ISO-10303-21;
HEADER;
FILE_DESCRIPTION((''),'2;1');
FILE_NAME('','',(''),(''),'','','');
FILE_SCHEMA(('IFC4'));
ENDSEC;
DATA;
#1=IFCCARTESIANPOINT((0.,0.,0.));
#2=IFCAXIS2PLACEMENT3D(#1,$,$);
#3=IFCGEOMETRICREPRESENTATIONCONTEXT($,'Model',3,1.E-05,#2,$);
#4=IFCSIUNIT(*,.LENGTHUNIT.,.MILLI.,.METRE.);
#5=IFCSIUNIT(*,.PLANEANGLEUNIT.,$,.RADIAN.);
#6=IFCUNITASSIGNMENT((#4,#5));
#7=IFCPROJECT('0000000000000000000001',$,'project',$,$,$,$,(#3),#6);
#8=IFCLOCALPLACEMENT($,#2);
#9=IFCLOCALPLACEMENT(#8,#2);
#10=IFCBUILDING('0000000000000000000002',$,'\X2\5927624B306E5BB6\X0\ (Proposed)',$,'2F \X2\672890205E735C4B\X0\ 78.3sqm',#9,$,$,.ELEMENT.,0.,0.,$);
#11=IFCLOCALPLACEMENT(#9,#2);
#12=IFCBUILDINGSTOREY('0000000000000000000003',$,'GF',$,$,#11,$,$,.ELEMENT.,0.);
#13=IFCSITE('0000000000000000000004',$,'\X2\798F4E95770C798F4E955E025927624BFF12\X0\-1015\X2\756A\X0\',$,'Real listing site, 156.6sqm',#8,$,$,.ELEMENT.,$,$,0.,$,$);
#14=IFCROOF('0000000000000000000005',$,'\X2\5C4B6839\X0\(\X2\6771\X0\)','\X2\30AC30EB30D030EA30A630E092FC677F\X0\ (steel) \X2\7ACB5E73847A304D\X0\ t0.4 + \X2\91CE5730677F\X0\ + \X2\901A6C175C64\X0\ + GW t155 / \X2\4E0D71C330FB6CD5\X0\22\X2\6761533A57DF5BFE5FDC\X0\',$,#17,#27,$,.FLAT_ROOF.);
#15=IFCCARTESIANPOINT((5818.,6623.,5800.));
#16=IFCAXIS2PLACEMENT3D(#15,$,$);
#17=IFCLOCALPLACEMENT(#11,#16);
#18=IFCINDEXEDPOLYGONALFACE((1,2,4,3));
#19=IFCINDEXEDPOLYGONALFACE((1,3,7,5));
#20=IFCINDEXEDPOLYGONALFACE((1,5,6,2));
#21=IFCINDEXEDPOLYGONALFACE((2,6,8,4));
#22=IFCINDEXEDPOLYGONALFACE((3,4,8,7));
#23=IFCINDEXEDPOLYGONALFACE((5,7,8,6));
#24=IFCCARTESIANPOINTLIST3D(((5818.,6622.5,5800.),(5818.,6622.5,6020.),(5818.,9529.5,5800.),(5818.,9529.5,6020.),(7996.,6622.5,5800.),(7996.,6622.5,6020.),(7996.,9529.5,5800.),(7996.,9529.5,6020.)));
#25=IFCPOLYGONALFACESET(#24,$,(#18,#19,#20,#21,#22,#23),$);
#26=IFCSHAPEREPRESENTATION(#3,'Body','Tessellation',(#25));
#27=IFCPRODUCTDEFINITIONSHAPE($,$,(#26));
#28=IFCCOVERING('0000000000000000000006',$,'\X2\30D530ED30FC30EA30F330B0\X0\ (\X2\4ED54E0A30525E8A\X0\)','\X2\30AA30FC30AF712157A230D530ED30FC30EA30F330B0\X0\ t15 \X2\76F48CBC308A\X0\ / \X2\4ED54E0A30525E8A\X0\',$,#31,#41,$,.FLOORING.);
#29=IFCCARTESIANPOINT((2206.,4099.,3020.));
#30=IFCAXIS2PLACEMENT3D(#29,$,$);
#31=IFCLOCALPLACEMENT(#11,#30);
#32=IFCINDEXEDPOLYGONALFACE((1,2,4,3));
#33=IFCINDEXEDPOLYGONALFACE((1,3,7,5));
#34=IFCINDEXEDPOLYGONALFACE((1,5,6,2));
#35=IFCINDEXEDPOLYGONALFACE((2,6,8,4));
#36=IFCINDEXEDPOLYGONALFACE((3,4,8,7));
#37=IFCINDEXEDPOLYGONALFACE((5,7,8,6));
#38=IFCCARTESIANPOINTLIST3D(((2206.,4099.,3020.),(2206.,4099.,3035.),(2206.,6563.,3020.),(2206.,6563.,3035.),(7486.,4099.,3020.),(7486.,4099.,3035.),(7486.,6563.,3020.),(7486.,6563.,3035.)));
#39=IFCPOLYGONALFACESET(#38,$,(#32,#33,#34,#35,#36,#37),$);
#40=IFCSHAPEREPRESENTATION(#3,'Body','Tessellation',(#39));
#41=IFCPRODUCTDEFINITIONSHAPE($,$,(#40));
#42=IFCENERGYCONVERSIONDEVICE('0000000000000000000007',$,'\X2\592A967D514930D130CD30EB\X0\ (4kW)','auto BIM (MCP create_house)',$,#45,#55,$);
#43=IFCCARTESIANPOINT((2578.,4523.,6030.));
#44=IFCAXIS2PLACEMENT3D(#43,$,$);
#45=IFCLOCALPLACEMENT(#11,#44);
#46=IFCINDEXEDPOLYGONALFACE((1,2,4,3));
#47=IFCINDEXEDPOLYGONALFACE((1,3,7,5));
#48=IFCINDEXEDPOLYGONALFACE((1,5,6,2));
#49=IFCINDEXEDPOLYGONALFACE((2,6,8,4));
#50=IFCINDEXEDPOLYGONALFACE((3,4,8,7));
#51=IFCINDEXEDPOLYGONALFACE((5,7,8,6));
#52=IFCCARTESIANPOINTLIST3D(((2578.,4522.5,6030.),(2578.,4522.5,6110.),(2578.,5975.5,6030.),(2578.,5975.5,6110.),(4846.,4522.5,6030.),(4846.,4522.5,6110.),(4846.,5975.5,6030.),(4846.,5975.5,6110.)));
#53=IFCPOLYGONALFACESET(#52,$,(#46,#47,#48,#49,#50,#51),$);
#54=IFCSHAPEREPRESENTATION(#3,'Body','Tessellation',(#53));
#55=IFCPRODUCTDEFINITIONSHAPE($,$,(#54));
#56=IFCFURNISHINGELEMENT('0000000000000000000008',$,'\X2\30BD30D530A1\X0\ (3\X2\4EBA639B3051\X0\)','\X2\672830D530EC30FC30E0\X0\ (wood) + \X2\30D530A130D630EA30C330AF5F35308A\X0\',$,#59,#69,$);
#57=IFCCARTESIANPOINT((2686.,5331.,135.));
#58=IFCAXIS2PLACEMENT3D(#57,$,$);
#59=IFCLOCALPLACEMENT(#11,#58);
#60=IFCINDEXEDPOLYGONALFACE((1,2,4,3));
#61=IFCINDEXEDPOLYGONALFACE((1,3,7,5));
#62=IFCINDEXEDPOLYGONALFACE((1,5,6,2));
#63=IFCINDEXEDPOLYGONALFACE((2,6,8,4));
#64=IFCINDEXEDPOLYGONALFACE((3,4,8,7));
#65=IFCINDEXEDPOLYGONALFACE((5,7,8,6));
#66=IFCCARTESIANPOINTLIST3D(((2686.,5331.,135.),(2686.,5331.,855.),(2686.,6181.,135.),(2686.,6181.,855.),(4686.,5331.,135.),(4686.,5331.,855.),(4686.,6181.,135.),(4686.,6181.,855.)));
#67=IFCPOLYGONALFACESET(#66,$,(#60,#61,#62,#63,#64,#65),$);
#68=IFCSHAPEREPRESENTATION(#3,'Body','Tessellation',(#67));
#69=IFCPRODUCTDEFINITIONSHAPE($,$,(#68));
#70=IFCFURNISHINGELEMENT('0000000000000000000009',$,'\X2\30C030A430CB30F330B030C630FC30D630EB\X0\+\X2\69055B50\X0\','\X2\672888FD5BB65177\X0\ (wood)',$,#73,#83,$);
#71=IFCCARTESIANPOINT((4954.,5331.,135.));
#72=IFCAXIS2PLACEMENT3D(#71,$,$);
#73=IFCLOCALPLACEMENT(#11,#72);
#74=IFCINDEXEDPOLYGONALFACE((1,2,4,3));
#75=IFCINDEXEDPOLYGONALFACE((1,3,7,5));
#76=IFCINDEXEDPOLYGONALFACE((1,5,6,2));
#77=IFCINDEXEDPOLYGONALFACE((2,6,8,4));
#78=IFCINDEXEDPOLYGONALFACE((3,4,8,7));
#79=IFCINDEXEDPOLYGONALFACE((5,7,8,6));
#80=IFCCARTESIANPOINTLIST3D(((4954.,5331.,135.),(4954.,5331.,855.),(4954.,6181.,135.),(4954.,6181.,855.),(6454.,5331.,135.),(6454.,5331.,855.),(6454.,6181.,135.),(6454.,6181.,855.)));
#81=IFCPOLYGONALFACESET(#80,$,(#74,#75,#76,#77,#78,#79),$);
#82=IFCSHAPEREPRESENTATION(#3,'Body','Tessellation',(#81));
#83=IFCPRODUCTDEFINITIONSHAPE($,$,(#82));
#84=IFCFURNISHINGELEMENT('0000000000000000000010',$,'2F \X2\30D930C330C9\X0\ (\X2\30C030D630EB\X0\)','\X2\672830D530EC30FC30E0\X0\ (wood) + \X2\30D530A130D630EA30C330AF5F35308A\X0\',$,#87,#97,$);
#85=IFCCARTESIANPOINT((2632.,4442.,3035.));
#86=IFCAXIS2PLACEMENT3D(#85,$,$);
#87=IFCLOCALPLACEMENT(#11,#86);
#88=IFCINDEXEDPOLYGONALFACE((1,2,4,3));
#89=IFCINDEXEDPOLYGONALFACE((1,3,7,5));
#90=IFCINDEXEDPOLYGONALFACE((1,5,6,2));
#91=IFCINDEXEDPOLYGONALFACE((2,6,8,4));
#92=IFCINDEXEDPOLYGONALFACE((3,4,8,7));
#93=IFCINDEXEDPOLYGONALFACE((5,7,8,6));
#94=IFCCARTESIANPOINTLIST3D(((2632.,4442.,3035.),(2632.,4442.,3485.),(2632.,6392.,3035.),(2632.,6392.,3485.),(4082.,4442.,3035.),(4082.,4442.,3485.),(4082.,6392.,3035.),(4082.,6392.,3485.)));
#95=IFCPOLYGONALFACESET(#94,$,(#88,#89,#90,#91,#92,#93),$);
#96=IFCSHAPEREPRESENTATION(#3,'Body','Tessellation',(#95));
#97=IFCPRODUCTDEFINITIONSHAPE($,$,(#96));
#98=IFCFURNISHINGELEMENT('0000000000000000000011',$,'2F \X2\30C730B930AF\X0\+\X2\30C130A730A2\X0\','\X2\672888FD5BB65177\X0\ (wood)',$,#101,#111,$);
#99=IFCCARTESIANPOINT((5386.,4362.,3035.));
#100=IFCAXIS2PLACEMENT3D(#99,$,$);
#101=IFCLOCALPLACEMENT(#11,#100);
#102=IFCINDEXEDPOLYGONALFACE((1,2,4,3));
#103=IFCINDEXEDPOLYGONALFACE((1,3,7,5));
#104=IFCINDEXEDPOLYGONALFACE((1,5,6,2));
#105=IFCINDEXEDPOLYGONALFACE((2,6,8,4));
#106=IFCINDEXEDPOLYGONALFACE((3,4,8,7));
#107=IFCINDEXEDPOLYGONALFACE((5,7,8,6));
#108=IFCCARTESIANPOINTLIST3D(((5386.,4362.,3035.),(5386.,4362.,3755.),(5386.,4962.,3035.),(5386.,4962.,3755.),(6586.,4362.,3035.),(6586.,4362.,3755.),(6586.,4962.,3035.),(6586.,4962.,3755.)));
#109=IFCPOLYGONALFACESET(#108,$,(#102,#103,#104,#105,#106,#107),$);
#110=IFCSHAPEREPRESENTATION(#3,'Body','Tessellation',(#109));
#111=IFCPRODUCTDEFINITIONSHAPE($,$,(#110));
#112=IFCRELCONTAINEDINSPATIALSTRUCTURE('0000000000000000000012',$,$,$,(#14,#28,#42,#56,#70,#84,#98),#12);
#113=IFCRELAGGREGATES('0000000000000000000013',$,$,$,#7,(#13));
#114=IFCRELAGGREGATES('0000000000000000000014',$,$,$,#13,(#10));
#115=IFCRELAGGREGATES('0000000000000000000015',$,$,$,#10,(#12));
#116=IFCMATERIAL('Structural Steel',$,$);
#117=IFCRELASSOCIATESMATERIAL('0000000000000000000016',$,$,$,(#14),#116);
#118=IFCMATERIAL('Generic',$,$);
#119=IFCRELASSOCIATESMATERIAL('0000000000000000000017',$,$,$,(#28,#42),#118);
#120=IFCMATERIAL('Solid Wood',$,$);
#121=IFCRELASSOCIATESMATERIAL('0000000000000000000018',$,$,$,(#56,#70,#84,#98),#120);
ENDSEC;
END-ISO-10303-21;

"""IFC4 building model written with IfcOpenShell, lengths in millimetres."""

from ifc_helpers import new_model, si_unit, frame, frame_2d, origin, place, context, project, spatial, rectangle, extrude, material, element, save


model = new_model("IFC4")

# Units and contexts
model_context = context("Model", 3, precision=1e-05, world=origin())
ifc_project = project(units=[si_unit("LENGTHUNIT", "METRE", prefix="MILLI"), si_unit("PLANEANGLEUNIT", "RADIAN")], contexts=[model_context])

# Site, building, storey
site_placement = place(None, origin())
site = spatial("IfcSite", under=ifc_project, at=site_placement, Name="福井県福井市大手２-1015番", ObjectType="Real listing site, 156.6sqm", CompositionType="ELEMENT", RefElevation=0.0)
building_placement = place(site_placement, origin())
building = spatial("IfcBuilding", under=site, at=building_placement, Name="大手の家 (Proposed)", ObjectType="2F 木造平屋 78.3sqm", CompositionType="ELEMENT", ElevationOfRefHeight=0.0, ElevationOfTerrain=0.0)
storey_placement = place(building_placement, origin())
storey = spatial("IfcBuildingStorey", under=building, at=storey_placement, Name="GF", CompositionType="ELEMENT", Elevation=0.0)

# Shared definitions
ifc_material_1 = material(Name="Solid Wood")

# Roof
ifc_material_2 = material(Name="Structural Steel")
roof_1_placement = place(storey_placement, frame((5818.0, 6623.0, 5800.0)))
element("IfcRoof", 1, at=roof_1_placement, inside=storey, material=ifc_material_2, Name="屋根(東)", Description="ガルバリウム鋼板 (steel) 立平葺き t0.4 + 野地板 + 通気層 + GW t155 / 不燃・法22条区域対応", PredefinedType="FLAT_ROOF", context=model_context, shape_type="SweptSolid", body=[
    extrude(rectangle(XDim=2178.0, YDim=2907.0, at=frame_2d((1089.0, 1453.0))), frame((5818.0, 6623.0, 5800.0)), (0.0, 0.0, 1.0), 220.0),
])

# Covering
ifc_material_3 = material(Name="Generic")
covering_placement = place(storey_placement, frame((2206.0, 4099.0, 3020.0)))
element("IfcCovering", 2, at=covering_placement, inside=storey, material=ifc_material_3, Name="フローリング (仕上げ床)", Description="オーク無垢フローリング t15 直貼り / 仕上げ床", PredefinedType="FLOORING", context=model_context, shape_type="SweptSolid", body=[
    extrude(rectangle(XDim=5280.0, YDim=2464.0, at=frame_2d((2640.0, 1232.0))), frame((2206.0, 4099.0, 3020.0)), (0.0, 0.0, 1.0), 15.0),
])

# Energy conversion device
energy_conversion_device_placement = place(storey_placement, frame((2578.0, 4523.0, 6030.0)))
element("IfcEnergyConversionDevice", 3, at=energy_conversion_device_placement, inside=storey, material=ifc_material_3, Name="太陽光パネル (4kW)", Description="auto BIM (MCP create_house)", context=model_context, shape_type="SweptSolid", body=[
    extrude(rectangle(XDim=2268.0, YDim=1453.0, at=frame_2d((1134.0, 726.0))), frame((2578.0, 4523.0, 6030.0)), (0.0, 0.0, 1.0), 80.0),
])

# Furnishing elements
furnishing_1_placement = place(storey_placement, frame((2686.0, 5331.0, 135.0)))
element("IfcFurnishingElement", 4, at=furnishing_1_placement, inside=storey, material=ifc_material_1, Name="ソファ (3人掛け)", Description="木フレーム (wood) + ファブリック張り", context=model_context, shape_type="SweptSolid", body=[
    extrude(rectangle(XDim=2000.0, YDim=850.0, at=frame_2d((1000.0, 425.0))), frame((2686.0, 5331.0, 135.0)), (0.0, 0.0, 1.0), 720.0),
])
furnishing_2_placement = place(storey_placement, frame((4954.0, 5331.0, 135.0)))
element("IfcFurnishingElement", 5, at=furnishing_2_placement, inside=storey, material=ifc_material_1, Name="ダイニングテーブル+椅子", Description="木製家具 (wood)", context=model_context, shape_type="SweptSolid", body=[
    extrude(rectangle(XDim=1500.0, YDim=850.0, at=frame_2d((750.0, 425.0))), frame((4954.0, 5331.0, 135.0)), (0.0, 0.0, 1.0), 720.0),
])
furnishing_3_placement = place(storey_placement, frame((2632.0, 4442.0, 3035.0)))
element("IfcFurnishingElement", 6, at=furnishing_3_placement, inside=storey, material=ifc_material_1, Name="2F ベッド (ダブル)", Description="木フレーム (wood) + ファブリック張り", context=model_context, shape_type="SweptSolid", body=[
    extrude(rectangle(XDim=1450.0, YDim=1950.0, at=frame_2d((725.0, 975.0))), frame((2632.0, 4442.0, 3035.0)), (0.0, 0.0, 1.0), 450.0),
])
furnishing_4_placement = place(storey_placement, frame((5386.0, 4362.0, 3035.0)))
element("IfcFurnishingElement", 7, at=furnishing_4_placement, inside=storey, material=ifc_material_1, Name="2F デスク+チェア", Description="木製家具 (wood)", context=model_context, shape_type="SweptSolid", body=[
    extrude(rectangle(XDim=1200.0, YDim=600.0, at=frame_2d((600.0, 300.0))), frame((5386.0, 4362.0, 3035.0)), (0.0, 0.0, 1.0), 720.0),
])

save(model, "model.ifc")
